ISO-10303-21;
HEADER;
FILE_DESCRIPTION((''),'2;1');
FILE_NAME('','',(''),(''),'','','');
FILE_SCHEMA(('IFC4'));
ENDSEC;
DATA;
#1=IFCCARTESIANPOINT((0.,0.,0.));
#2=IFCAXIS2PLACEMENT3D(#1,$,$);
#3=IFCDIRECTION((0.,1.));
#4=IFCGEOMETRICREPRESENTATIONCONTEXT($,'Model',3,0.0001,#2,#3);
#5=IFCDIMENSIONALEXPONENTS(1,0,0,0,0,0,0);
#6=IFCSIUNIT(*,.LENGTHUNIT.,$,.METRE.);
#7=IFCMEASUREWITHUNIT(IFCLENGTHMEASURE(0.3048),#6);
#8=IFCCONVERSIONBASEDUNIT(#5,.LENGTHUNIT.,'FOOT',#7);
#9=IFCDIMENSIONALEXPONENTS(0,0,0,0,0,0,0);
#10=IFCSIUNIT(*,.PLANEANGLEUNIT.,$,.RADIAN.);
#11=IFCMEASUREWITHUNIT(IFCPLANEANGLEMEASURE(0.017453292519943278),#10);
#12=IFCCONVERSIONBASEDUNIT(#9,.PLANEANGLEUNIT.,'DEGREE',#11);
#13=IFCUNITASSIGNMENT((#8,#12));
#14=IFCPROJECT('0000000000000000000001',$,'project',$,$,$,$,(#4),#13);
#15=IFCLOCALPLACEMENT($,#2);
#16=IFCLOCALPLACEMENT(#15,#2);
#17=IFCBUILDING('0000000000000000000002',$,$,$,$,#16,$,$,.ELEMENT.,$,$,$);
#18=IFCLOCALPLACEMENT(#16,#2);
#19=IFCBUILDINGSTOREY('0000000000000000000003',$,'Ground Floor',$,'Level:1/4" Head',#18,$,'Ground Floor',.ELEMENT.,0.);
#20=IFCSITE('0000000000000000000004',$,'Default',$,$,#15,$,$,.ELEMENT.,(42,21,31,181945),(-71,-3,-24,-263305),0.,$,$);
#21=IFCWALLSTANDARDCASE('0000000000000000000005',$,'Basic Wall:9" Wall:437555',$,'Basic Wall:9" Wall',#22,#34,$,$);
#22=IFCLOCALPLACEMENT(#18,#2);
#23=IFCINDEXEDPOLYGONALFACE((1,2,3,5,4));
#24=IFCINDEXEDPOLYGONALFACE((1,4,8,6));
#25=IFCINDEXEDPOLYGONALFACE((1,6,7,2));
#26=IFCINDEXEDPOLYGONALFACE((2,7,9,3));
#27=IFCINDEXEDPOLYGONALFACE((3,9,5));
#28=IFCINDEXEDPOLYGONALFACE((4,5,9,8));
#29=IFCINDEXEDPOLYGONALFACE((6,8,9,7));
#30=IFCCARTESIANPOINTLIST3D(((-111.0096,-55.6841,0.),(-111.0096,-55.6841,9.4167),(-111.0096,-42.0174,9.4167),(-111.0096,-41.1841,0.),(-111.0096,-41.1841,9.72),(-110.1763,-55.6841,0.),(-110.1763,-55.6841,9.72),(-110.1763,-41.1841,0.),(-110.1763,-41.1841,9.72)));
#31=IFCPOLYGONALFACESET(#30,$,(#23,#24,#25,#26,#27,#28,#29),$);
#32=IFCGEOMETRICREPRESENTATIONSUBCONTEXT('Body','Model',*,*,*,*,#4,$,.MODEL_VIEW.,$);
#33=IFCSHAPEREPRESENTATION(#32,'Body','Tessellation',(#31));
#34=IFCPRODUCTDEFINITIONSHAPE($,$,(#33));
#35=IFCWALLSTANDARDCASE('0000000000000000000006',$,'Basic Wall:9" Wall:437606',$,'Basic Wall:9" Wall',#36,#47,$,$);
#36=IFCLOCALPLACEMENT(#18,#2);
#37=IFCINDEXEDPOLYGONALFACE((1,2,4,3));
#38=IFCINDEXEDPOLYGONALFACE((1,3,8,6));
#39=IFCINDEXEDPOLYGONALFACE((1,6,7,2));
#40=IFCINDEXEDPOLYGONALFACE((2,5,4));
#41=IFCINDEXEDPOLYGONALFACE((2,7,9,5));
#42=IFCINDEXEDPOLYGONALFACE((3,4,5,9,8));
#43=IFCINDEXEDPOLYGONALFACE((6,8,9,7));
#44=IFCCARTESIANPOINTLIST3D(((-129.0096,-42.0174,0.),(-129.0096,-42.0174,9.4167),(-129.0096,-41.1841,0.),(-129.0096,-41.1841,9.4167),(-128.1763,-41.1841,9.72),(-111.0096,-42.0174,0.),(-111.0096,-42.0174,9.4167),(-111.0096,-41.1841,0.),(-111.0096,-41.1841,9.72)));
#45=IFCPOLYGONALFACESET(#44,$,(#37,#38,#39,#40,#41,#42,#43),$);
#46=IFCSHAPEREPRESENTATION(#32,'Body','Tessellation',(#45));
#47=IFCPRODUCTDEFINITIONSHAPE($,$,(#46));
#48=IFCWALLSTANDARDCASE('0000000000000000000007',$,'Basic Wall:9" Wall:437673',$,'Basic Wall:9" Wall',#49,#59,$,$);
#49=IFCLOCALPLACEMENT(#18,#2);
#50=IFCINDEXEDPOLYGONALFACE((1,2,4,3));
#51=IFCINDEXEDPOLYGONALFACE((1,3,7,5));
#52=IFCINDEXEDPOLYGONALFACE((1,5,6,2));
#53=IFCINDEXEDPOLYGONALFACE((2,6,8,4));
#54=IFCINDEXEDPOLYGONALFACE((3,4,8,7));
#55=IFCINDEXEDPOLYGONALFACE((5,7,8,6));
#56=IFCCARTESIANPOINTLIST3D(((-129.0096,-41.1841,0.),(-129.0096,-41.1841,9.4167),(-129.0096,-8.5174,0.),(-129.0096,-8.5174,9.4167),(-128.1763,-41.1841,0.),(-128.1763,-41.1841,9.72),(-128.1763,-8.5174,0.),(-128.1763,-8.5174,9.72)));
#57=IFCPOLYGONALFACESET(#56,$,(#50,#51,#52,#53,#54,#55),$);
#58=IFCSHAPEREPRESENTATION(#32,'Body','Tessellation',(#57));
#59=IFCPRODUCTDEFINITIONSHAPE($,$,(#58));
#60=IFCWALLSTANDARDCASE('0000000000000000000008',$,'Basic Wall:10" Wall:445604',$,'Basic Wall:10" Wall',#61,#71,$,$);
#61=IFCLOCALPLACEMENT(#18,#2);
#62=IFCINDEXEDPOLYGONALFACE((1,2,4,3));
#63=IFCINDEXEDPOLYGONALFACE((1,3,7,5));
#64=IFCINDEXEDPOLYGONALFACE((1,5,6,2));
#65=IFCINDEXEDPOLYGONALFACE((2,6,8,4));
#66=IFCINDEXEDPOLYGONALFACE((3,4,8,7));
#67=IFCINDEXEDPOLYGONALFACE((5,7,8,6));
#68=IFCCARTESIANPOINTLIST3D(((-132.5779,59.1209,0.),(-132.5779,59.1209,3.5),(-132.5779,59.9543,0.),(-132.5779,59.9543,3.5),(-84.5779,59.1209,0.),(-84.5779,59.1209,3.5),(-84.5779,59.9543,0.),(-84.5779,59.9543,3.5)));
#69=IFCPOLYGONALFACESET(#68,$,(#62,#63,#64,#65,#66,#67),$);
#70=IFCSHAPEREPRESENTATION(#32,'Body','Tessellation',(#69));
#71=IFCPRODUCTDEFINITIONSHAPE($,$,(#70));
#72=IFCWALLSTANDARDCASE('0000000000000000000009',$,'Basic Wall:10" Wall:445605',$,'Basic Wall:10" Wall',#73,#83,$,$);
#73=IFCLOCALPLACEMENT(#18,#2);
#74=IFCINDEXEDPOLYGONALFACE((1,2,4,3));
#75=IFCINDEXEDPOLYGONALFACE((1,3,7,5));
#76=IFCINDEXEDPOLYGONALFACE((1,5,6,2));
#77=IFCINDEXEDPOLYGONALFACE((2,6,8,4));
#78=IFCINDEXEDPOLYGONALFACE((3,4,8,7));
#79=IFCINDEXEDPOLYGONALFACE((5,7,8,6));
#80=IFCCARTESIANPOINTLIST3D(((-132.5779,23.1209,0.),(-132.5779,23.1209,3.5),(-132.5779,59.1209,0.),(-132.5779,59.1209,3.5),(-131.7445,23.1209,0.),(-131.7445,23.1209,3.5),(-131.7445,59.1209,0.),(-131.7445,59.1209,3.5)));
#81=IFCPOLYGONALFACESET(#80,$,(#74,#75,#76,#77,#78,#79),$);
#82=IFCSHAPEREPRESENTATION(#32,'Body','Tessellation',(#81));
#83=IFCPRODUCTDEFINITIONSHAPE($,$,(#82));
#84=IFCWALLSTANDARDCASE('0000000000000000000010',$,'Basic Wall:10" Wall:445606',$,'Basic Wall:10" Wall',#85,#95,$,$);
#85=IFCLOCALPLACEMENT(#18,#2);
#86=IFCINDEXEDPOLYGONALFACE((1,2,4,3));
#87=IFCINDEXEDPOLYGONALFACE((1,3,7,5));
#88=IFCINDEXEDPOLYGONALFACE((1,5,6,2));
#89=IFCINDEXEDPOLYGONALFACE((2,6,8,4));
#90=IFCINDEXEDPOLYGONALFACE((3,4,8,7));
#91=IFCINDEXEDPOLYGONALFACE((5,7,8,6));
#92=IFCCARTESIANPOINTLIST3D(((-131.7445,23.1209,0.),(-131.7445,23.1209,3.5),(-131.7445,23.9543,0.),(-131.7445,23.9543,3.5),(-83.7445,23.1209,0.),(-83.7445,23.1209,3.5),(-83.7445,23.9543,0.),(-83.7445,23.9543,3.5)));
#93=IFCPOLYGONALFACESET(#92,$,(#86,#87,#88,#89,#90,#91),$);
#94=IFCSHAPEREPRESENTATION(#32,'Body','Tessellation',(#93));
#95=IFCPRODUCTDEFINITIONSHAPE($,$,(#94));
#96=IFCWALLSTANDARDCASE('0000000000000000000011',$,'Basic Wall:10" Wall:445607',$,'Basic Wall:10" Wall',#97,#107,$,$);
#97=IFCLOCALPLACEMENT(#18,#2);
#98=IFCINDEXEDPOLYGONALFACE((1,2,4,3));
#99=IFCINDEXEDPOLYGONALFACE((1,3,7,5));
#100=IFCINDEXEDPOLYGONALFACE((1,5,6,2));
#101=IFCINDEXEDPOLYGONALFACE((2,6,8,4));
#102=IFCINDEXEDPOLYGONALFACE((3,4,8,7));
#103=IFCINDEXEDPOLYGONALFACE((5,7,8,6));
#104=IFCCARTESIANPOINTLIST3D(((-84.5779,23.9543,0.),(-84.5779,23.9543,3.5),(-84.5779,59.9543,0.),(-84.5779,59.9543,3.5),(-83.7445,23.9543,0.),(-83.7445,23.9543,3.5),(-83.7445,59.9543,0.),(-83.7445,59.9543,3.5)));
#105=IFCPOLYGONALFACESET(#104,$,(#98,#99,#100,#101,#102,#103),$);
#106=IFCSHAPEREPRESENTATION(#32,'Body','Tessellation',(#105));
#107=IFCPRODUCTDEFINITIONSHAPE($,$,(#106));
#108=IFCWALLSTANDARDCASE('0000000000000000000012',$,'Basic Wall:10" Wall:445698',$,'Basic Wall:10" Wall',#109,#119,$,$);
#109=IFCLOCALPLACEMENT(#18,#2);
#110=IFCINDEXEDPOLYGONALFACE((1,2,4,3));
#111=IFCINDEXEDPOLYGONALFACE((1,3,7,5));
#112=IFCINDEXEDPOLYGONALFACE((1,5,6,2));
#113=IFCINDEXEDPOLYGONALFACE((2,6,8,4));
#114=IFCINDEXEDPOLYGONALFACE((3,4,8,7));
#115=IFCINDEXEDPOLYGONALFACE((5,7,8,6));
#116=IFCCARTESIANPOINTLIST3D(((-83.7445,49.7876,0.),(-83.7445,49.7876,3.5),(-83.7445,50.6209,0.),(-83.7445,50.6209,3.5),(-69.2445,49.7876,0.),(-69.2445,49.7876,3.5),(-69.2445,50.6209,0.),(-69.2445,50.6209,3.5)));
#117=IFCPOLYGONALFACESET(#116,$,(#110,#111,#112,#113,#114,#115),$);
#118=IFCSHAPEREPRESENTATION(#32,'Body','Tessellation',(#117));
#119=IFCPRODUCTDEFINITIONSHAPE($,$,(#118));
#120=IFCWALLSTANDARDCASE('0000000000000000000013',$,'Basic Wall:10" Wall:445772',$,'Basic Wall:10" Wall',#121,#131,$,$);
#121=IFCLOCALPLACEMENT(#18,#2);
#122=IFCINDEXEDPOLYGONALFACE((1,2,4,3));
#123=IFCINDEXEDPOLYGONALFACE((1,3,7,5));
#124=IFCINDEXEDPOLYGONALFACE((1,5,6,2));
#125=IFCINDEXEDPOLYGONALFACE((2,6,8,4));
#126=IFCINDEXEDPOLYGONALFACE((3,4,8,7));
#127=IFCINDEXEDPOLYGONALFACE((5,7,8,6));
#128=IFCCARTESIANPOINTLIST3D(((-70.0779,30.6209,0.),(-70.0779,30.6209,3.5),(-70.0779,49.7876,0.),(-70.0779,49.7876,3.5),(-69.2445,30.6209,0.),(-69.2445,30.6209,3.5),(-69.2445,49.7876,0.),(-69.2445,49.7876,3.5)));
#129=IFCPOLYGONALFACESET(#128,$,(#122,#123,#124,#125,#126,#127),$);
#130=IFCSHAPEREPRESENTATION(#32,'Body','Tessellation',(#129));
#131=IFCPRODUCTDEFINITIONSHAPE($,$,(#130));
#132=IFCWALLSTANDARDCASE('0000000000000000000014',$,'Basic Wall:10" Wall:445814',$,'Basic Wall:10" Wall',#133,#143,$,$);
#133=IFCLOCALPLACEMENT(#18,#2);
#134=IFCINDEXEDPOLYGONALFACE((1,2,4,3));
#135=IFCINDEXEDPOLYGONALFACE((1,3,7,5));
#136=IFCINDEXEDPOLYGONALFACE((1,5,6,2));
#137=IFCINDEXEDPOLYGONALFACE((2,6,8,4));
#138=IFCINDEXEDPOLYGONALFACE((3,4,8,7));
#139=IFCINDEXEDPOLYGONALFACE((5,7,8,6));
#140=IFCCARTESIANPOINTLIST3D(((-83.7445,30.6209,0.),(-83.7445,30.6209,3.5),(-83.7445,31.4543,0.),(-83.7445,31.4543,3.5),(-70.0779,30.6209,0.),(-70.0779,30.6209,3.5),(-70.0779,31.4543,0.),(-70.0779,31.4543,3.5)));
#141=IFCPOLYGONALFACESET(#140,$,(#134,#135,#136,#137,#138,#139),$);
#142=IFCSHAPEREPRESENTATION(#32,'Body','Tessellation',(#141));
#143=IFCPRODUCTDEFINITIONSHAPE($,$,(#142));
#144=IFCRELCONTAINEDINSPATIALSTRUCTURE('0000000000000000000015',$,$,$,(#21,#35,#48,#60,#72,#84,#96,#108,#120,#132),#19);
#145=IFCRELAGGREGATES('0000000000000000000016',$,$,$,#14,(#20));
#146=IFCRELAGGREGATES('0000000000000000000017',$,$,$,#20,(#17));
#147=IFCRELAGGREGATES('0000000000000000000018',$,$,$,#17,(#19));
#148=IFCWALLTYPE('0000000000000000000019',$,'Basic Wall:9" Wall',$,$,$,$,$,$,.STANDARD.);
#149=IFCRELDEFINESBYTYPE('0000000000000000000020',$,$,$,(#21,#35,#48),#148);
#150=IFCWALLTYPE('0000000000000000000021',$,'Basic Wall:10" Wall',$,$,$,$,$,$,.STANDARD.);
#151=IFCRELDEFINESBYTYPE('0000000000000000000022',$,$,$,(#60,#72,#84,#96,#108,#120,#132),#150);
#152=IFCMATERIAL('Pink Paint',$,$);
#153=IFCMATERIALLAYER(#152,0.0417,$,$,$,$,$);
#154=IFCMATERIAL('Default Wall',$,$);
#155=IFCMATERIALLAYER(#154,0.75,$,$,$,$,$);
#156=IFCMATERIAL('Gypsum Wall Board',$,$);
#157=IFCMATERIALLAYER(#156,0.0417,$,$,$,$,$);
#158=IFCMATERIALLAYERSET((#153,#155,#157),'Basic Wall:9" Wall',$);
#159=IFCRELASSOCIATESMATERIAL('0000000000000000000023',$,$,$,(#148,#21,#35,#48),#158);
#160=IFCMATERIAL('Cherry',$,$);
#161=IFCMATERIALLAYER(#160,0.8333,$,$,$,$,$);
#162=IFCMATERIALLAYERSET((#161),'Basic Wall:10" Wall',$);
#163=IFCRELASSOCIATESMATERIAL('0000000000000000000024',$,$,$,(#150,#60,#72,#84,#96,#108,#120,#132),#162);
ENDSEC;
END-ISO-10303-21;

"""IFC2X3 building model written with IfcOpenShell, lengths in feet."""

from ifc_helpers import new_model, entity, si_unit, converted_unit, direction, frame, frame_2d, origin, place, context, subcontext, project, spatial, polyline, rectangle, extrude, clip, bounded_halfspace, material, layer, layer_set, layer_usage, type_object, element, save


model = new_model("IFC2X3")

# Units and contexts
model_context = context("Model", 3, precision=0.0001, world=origin(), true_north=direction((0.0, 1.0)))
body_context = subcontext(model_context, "Body", "Model", "MODEL_VIEW")
ifc_project = project(units=[converted_unit("LENGTHUNIT", "FOOT", entity("IfcLengthMeasure", 0.3048), si_unit("LENGTHUNIT", "METRE"), dimensions=[1, 0, 0, 0, 0, 0, 0]), converted_unit("PLANEANGLEUNIT", "DEGREE", entity("IfcPlaneAngleMeasure", 0.017453292519943278), si_unit("PLANEANGLEUNIT", "RADIAN"), dimensions=[0, 0, 0, 0, 0, 0, 0])], contexts=[model_context])

# Site, building, storey
site_placement = place(None, origin())
site = spatial("IfcSite", under=ifc_project, at=site_placement, Name="Default", CompositionType="ELEMENT", RefLatitude=(42, 21, 31, 181945), RefLongitude=(-71, -3, -24, -263305), RefElevation=0.0)
building_placement = place(site_placement, origin())
building = spatial("IfcBuilding", under=site, at=building_placement, CompositionType="ELEMENT")
storey_placement = place(building_placement, origin())
storey = spatial("IfcBuildingStorey", under=building, at=storey_placement, Name="Ground Floor", ObjectType="Level:1/4\" Head", LongName="Ground Floor", CompositionType="ELEMENT", Elevation=0.0)

# Walls
ifc_material_1 = material(Name="Pink Paint")
ifc_layer_1 = layer(ifc_material_1, 0.0417)
ifc_material_2 = material(Name="Default Wall")
ifc_layer_2 = layer(ifc_material_2, 0.75)
ifc_material_3 = material(Name="Gypsum Wall Board")
ifc_layer_3 = layer(ifc_material_3, 0.0417)
ifc_layer_set_1 = layer_set([ifc_layer_1, ifc_layer_2, ifc_layer_3], Name="Basic Wall:9\" Wall")
ifc_layer_usage_1 = layer_usage(ifc_layer_set_1, "AXIS2", "NEGATIVE", 0.4167)
wall_type_1 = type_object("IfcWallType", Name="Basic Wall:9\" Wall", PredefinedType="STANDARD", material=ifc_layer_set_1)
wall_1_placement = place(storey_placement, frame((-110.593, -55.6841, 0.0), z_axis=(0.0, 0.0, 1.0), x_axis=(0.0, 1.0, 0.0)))
element("IfcWallStandardCase", 1, at=wall_1_placement, inside=storey, type_object=wall_type_1, material=ifc_layer_usage_1, Name="Basic Wall:9\" Wall:437555", ObjectType="Basic Wall:9\" Wall", context=body_context, shape_type="Clipping", body=[
    clip(clip(extrude(rectangle(XDim=14.5, YDim=0.8333, at=frame_2d((7.25, 0.0), x_axis=(-1.0, 0.0))), origin(), (0.0, 0.0, 1.0), 9.72), bounded_halfspace(frame((0.0, -0.4167, 9.72), z_axis=(0.0, 0.34202, 0.939693), x_axis=(-1.0, 0.0, 0.0)), False, frame((0.0, -0.4167, 9.72)), polyline([(0.0, 0.0), (14.5, 0.0), (13.6667, 0.8333), (0.0, 0.8333), (0.0, 0.0)]))), bounded_halfspace(frame((14.5, -0.4167, 9.72), z_axis=(-0.34202, 0.0, 0.939693), x_axis=(0.0, -1.0, 0.0)), False, frame((14.5, -0.4167, 9.72)), polyline([(0.0, 0.0), (0.0, 0.8333), (-0.8333, 0.8333), (0.0, 0.0)]))),
])
wall_2_placement = place(storey_placement, frame((-111.0096, -41.6008, 0.0), z_axis=(0.0, 0.0, 1.0), x_axis=(-1.0, 0.0, 0.0)))
element("IfcWallStandardCase", 2, at=wall_2_placement, inside=storey, type_object=wall_type_1, material=ifc_layer_usage_1, Name="Basic Wall:9\" Wall:437606", ObjectType="Basic Wall:9\" Wall", context=body_context, shape_type="Clipping", body=[
    clip(clip(extrude(rectangle(XDim=18.0, YDim=0.8333, at=frame_2d((9.0, 0.0), x_axis=(-1.0, 0.0))), origin(), (0.0, 0.0, 1.0), 9.72), bounded_halfspace(frame((17.1667, -0.4167, 9.72), z_axis=(0.34202, 0.0, 0.939693), x_axis=(0.0, 1.0, 0.0)), False, frame((17.1667, -0.4167, 9.72)), polyline([(0.0, 0.0), (0.8333, 0.0), (0.8333, 0.8333), (0.0, 0.0)]))), bounded_halfspace(frame((0.0, -0.4167, 9.72), z_axis=(0.0, 0.34202, 0.939693), x_axis=(-1.0, 0.0, 0.0)), False, frame((0.0, -0.4167, 9.72)), polyline([(0.0, 0.0), (17.1667, 0.0), (18.0, 0.8333), (0.0, 0.8333), (0.0, 0.0)]))),
])
wall_3_placement = place(storey_placement, frame((-128.593, -41.1841, 0.0), z_axis=(0.0, 0.0, 1.0), x_axis=(0.0, 1.0, 0.0)))
element("IfcWallStandardCase", 3, at=wall_3_placement, inside=storey, type_object=wall_type_1, material=ifc_layer_usage_1, Name="Basic Wall:9\" Wall:437673", ObjectType="Basic Wall:9\" Wall", context=body_context, shape_type="Clipping", body=[
    clip(extrude(rectangle(XDim=32.6667, YDim=0.8333, at=frame_2d((16.3333, 0.0), x_axis=(-1.0, 0.0))), origin(), (0.0, 0.0, 1.0), 9.72), bounded_halfspace(frame((0.0, -0.4167, 9.72), z_axis=(0.0, 0.34202, 0.939693), x_axis=(-1.0, 0.0, 0.0)), False, frame((0.0, -0.4167, 9.72)), polyline([(0.0, 0.0), (32.6667, 0.0), (32.6667, 0.8333), (0.0, 0.8333), (0.0, 0.0)]))),
])
ifc_material_4 = material(Name="Cherry")
ifc_layer_4 = layer(ifc_material_4, 0.8333)
ifc_layer_set_2 = layer_set([ifc_layer_4], Name="Basic Wall:10\" Wall")
ifc_layer_usage_2 = layer_usage(ifc_layer_set_2, "AXIS2", "NEGATIVE", 0.4167)
wall_type_2 = type_object("IfcWallType", Name="Basic Wall:10\" Wall", PredefinedType="STANDARD", material=ifc_layer_set_2)
wall_4_placement = place(storey_placement, frame((-132.5779, 59.5376, 0.0)))
element("IfcWallStandardCase", 4, at=wall_4_placement, inside=storey, type_object=wall_type_2, material=ifc_layer_usage_2, Name="Basic Wall:10\" Wall:445604", ObjectType="Basic Wall:10\" Wall", context=body_context, shape_type="SweptSolid", body=[
    extrude(rectangle(XDim=48.0, YDim=0.8333, at=frame_2d((24.0, 0.0), x_axis=(-1.0, 0.0))), origin(), (0.0, 0.0, 1.0), 3.5),
])
wall_5_placement = place(storey_placement, frame((-132.1612, 23.1209, 0.0), z_axis=(0.0, 0.0, 1.0), x_axis=(0.0, 1.0, 0.0)))
element("IfcWallStandardCase", 5, at=wall_5_placement, inside=storey, type_object=wall_type_2, material=ifc_layer_usage_2, Name="Basic Wall:10\" Wall:445605", ObjectType="Basic Wall:10\" Wall", context=body_context, shape_type="SweptSolid", body=[
    extrude(rectangle(XDim=36.0, YDim=0.8333, at=frame_2d((18.0, 0.0), x_axis=(-1.0, 0.0))), origin(), (0.0, 0.0, 1.0), 3.5),
])
wall_6_placement = place(storey_placement, frame((-83.7445, 23.5376, 0.0), z_axis=(0.0, 0.0, 1.0), x_axis=(-1.0, 0.0, 0.0)))
element("IfcWallStandardCase", 6, at=wall_6_placement, inside=storey, type_object=wall_type_2, material=ifc_layer_usage_2, Name="Basic Wall:10\" Wall:445606", ObjectType="Basic Wall:10\" Wall", context=body_context, shape_type="SweptSolid", body=[
    extrude(rectangle(XDim=48.0, YDim=0.8333, at=frame_2d((24.0, 0.0), x_axis=(-1.0, 0.0))), origin(), (0.0, 0.0, 1.0), 3.5),
])
wall_7_placement = place(storey_placement, frame((-84.1612, 59.9543, 0.0), z_axis=(0.0, 0.0, 1.0), x_axis=(0.0, -1.0, 0.0)))
element("IfcWallStandardCase", 7, at=wall_7_placement, inside=storey, type_object=wall_type_2, material=ifc_layer_usage_2, Name="Basic Wall:10\" Wall:445607", ObjectType="Basic Wall:10\" Wall", context=body_context, shape_type="SweptSolid", body=[
    extrude(rectangle(XDim=36.0, YDim=0.8333, at=frame_2d((18.0, 0.0), x_axis=(-1.0, 0.0))), origin(), (0.0, 0.0, 1.0), 3.5),
])
wall_8_placement = place(storey_placement, frame((-83.7445, 50.2043, 0.0)))
element("IfcWallStandardCase", 8, at=wall_8_placement, inside=storey, type_object=wall_type_2, material=ifc_layer_usage_2, Name="Basic Wall:10\" Wall:445698", ObjectType="Basic Wall:10\" Wall", context=body_context, shape_type="SweptSolid", body=[
    extrude(rectangle(XDim=14.5, YDim=0.8333, at=frame_2d((7.25, 0.0), x_axis=(-1.0, 0.0))), origin(), (0.0, 0.0, 1.0), 3.5),
])
wall_9_placement = place(storey_placement, frame((-69.6612, 49.7876, 0.0), z_axis=(0.0, 0.0, 1.0), x_axis=(0.0, -1.0, 0.0)))
element("IfcWallStandardCase", 9, at=wall_9_placement, inside=storey, type_object=wall_type_2, material=ifc_layer_usage_2, Name="Basic Wall:10\" Wall:445772", ObjectType="Basic Wall:10\" Wall", context=body_context, shape_type="SweptSolid", body=[
    extrude(rectangle(XDim=19.1667, YDim=0.8333, at=frame_2d((9.5833, 0.0), x_axis=(-1.0, 0.0))), origin(), (0.0, 0.0, 1.0), 3.5),
])
wall_10_placement = place(storey_placement, frame((-70.0779, 31.0376, 0.0), z_axis=(0.0, 0.0, 1.0), x_axis=(-1.0, 0.0, 0.0)))
element("IfcWallStandardCase", 10, at=wall_10_placement, inside=storey, type_object=wall_type_2, material=ifc_layer_usage_2, Name="Basic Wall:10\" Wall:445814", ObjectType="Basic Wall:10\" Wall", context=body_context, shape_type="SweptSolid", body=[
    extrude(rectangle(XDim=13.6667, YDim=0.8333, at=frame_2d((6.8333, 0.0), x_axis=(-1.0, 0.0))), origin(), (0.0, 0.0, 1.0), 3.5),
])

save(model, "model.ifc")
